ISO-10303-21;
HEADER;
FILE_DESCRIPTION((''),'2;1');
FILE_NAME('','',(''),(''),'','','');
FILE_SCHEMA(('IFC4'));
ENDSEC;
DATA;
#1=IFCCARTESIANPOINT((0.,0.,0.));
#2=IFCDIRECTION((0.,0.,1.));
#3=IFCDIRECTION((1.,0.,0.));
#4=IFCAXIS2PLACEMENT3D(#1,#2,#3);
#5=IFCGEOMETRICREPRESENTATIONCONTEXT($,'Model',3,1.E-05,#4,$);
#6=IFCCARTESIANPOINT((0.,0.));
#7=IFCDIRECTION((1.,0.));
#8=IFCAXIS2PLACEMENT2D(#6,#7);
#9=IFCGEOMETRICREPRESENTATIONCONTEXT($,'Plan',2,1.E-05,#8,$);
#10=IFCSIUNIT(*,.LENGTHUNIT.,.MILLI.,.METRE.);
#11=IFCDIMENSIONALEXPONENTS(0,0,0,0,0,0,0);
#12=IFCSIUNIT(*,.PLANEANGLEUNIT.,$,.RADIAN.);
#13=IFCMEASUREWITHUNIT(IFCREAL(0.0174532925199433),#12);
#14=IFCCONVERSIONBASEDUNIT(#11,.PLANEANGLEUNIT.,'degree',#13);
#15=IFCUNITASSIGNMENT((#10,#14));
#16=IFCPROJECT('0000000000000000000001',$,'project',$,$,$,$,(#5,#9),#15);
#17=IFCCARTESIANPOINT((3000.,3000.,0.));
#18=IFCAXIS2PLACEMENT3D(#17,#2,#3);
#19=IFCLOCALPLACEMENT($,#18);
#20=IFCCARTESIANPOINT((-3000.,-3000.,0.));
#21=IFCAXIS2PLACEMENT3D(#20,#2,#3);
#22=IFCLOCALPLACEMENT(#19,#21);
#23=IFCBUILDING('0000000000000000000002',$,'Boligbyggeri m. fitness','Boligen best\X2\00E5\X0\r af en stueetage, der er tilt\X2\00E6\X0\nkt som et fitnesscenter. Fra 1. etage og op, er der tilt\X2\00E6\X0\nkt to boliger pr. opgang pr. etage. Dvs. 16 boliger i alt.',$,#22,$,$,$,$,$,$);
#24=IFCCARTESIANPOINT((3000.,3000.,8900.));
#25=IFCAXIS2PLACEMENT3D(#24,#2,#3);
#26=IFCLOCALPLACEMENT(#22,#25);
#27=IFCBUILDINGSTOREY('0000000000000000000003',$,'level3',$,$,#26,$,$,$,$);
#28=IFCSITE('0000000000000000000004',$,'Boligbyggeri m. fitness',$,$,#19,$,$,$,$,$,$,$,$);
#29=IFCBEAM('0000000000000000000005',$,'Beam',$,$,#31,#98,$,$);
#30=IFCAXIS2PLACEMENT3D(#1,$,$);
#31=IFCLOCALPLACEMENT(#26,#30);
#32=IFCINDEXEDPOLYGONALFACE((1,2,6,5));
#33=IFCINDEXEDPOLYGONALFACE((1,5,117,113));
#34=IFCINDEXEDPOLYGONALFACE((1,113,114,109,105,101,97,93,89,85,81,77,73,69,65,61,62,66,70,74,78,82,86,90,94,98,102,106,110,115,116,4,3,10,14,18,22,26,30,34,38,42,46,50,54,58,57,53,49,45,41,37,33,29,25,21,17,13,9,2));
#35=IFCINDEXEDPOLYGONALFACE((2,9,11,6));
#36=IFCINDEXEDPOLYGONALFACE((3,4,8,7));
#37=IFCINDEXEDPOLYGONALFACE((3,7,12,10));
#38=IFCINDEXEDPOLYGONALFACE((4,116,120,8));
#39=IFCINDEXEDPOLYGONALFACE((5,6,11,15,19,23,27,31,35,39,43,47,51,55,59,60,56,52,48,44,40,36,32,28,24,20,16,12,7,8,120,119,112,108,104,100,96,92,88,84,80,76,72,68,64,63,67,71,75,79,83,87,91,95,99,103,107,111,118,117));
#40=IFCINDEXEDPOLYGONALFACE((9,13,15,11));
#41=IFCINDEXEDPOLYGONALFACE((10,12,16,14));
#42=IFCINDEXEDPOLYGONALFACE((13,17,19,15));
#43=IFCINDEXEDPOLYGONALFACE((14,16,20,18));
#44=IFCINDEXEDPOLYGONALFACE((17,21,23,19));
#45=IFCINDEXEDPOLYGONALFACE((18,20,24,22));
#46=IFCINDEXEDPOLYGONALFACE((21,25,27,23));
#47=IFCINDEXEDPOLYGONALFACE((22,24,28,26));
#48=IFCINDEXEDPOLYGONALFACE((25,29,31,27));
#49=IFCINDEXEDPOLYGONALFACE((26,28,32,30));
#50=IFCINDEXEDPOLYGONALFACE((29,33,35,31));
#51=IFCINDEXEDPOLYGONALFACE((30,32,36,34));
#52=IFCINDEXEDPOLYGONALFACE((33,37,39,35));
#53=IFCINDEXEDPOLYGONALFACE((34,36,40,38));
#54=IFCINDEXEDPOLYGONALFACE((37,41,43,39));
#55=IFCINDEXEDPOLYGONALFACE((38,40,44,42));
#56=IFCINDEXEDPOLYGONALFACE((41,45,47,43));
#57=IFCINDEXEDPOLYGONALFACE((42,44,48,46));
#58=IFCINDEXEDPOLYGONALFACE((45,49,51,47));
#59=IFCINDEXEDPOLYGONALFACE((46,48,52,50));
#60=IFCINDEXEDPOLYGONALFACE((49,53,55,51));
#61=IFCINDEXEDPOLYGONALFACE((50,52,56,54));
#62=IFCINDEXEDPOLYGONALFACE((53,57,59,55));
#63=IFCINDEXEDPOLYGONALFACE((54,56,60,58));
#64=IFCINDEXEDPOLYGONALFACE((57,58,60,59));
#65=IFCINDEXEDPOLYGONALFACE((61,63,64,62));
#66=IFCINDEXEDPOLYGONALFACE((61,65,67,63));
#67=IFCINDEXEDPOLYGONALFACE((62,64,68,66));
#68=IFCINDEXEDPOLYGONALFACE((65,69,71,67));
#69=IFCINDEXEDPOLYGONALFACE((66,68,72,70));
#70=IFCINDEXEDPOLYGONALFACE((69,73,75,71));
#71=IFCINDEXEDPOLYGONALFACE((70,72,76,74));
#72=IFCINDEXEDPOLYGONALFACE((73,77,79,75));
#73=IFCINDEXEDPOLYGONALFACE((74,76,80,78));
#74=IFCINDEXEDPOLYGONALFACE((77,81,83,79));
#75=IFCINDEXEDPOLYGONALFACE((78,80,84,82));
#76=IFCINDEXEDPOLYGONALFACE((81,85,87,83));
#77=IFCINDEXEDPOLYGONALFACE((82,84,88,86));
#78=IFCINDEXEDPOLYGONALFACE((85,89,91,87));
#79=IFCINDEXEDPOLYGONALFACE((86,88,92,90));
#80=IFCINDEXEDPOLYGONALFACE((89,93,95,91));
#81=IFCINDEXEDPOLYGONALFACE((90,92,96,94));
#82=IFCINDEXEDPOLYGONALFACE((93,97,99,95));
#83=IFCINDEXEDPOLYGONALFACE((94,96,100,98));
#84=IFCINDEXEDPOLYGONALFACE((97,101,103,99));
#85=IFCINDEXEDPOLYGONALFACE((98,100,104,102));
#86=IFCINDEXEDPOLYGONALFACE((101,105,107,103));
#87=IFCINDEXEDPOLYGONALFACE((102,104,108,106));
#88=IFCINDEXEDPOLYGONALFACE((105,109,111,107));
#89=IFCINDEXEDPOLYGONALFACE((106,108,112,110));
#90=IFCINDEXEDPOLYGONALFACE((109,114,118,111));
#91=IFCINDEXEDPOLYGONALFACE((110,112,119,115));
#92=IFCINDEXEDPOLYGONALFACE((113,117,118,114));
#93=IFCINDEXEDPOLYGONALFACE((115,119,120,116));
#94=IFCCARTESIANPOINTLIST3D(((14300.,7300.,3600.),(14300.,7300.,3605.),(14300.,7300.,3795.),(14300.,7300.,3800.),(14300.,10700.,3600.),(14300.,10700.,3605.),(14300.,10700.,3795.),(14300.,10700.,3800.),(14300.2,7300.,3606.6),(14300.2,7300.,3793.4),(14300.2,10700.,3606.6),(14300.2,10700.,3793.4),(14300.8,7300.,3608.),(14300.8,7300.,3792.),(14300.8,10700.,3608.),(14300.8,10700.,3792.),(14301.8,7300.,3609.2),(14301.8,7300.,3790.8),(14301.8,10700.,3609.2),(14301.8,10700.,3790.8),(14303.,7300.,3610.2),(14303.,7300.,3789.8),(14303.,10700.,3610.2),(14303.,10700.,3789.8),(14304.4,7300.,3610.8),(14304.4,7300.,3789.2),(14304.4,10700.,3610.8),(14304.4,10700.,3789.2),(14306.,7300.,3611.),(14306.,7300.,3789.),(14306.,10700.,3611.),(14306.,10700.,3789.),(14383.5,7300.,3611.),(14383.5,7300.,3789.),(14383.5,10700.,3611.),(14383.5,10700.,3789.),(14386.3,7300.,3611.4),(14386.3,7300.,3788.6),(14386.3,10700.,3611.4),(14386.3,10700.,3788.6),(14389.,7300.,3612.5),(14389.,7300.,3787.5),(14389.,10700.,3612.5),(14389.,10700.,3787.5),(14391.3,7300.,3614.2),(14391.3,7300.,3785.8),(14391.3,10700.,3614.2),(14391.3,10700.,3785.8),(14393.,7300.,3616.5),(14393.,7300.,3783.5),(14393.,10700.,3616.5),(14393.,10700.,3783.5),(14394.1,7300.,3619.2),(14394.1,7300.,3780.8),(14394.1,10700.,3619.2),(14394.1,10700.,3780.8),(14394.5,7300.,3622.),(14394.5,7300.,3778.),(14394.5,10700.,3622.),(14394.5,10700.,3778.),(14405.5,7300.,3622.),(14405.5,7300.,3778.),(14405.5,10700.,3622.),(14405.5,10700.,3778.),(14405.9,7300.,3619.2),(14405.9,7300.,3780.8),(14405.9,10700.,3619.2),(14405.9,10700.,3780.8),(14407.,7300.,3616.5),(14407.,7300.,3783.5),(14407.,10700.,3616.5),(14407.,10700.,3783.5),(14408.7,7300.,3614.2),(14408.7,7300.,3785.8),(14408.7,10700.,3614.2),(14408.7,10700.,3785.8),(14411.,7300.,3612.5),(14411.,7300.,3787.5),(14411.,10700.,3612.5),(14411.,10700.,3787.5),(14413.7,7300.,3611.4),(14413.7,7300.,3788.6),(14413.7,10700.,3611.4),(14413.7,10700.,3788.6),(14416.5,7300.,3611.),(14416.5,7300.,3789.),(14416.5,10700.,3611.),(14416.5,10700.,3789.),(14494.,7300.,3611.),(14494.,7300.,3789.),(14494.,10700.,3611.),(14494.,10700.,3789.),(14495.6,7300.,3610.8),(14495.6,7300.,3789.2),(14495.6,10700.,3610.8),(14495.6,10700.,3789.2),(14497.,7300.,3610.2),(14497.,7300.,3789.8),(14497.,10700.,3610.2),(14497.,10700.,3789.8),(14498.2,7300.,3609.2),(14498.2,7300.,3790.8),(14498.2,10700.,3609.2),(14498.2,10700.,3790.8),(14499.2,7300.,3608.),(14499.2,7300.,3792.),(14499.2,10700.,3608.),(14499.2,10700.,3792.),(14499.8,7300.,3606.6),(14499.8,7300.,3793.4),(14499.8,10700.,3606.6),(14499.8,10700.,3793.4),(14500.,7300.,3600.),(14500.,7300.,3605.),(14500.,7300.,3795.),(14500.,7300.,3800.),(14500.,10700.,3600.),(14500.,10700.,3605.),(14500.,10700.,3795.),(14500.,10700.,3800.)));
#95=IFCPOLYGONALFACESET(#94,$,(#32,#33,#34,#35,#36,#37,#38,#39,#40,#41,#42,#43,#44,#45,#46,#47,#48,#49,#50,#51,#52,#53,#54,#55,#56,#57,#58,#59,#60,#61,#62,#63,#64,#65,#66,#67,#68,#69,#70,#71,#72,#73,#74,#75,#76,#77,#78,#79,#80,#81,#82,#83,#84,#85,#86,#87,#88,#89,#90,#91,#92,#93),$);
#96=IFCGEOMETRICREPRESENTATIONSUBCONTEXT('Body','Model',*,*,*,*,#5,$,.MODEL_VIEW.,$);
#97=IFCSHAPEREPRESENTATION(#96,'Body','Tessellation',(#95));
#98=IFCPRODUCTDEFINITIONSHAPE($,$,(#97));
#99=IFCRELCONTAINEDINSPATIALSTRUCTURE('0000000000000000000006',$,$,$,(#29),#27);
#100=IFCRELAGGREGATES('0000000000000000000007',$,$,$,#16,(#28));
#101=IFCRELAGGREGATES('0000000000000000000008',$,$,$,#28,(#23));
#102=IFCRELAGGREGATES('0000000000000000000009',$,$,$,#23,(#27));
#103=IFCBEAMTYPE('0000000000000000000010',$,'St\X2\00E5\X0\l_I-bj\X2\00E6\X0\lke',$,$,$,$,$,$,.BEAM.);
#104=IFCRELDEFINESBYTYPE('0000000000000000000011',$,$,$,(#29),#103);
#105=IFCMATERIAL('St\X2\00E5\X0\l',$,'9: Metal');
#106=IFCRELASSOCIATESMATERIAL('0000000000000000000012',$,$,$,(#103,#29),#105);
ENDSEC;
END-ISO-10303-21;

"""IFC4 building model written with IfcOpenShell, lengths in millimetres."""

from ifc_helpers import new_model, entity, si_unit, converted_unit, frame, origin_with_axes, origin_2d_with_axis, place, context, subcontext, project, spatial, i_section, extrude, material, material_profile, profile_set, profile_usage, type_object, element, save


model = new_model("IFC4")

# Units and contexts
model_context = context("Model", 3, precision=1e-05, world=origin_with_axes())
plan_context = context("Plan", 2, precision=1e-05, world=origin_2d_with_axis())
body_context = subcontext(model_context, "Body", "Model", "MODEL_VIEW")
ifc_project = project(units=[si_unit("LENGTHUNIT", "METRE", prefix="MILLI"), converted_unit("PLANEANGLEUNIT", "degree", entity("IfcReal", 0.0174532925199433), si_unit("PLANEANGLEUNIT", "RADIAN"), dimensions=[0, 0, 0, 0, 0, 0, 0])], contexts=[model_context, plan_context])

# Site, building, storey
site_placement = place(None, frame((3000.0, 3000.0, 0.0), z_axis=(0.0, 0.0, 1.0), x_axis=(1.0, 0.0, 0.0)))
site = spatial("IfcSite", under=ifc_project, at=site_placement, Name="Boligbyggeri m. fitness")
building_placement = place(site_placement, frame((-3000.0, -3000.0, 0.0), z_axis=(0.0, 0.0, 1.0), x_axis=(1.0, 0.0, 0.0)))
building = spatial("IfcBuilding", under=site, at=building_placement, Name="Boligbyggeri m. fitness", Description="Boligen består af en stueetage, der er tiltænkt som et fitnesscenter. Fra 1. etage og op, er der tiltænkt to boliger pr. opgang pr. etage. Dvs. 16 boliger i alt.")
storey_placement = place(building_placement, frame((3000.0, 3000.0, 8900.0), z_axis=(0.0, 0.0, 1.0), x_axis=(1.0, 0.0, 0.0)))
storey = spatial("IfcBuildingStorey", under=building, at=storey_placement, Name="level3")

# Beam
ifc_material_1 = material(Name="Stål", Category="9: Metal")
ifc_material_profile_1 = material_profile(ifc_material_1, i_section(OverallWidth=200.0, OverallDepth=200.0, WebThickness=11.0, FlangeThickness=11.0, FilletRadius=11.0, FlangeEdgeRadius=6.0), Name="Stål", Category="9: Metal")
ifc_profile_set_1 = profile_set([ifc_material_profile_1], Name="NY_I-Profil")
beam_type = type_object("IfcBeamType", Name="Stål_I-bjælke", PredefinedType="BEAM", material=ifc_profile_set_1)
ifc_profile_usage_1 = profile_usage(ifc_profile_set_1, cardinal=9)
beam_1_placement = place(storey_placement, frame((14500.0, 7300.0, 3800.0), z_axis=(0.0, 1.0, 0.0), x_axis=(-1.0, 0.0, 0.0)))
element("IfcBeam", 1, at=beam_1_placement, inside=storey, type_object=beam_type, material=ifc_profile_usage_1, Name="Beam", context=body_context, shape_type="SweptSolid", body=[
    extrude(i_section(OverallWidth=200.0, OverallDepth=200.0, WebThickness=11.0, FlangeThickness=11.0, FilletRadius=11.0, FlangeEdgeRadius=6.0), frame((100.0, -100.0, 0.0), z_axis=(0.0, 0.0, 1.0), x_axis=(1.0, 0.0, 0.0)), (0.0, 0.0, 1.0), 3400.0),
])

save(model, "model.ifc")
